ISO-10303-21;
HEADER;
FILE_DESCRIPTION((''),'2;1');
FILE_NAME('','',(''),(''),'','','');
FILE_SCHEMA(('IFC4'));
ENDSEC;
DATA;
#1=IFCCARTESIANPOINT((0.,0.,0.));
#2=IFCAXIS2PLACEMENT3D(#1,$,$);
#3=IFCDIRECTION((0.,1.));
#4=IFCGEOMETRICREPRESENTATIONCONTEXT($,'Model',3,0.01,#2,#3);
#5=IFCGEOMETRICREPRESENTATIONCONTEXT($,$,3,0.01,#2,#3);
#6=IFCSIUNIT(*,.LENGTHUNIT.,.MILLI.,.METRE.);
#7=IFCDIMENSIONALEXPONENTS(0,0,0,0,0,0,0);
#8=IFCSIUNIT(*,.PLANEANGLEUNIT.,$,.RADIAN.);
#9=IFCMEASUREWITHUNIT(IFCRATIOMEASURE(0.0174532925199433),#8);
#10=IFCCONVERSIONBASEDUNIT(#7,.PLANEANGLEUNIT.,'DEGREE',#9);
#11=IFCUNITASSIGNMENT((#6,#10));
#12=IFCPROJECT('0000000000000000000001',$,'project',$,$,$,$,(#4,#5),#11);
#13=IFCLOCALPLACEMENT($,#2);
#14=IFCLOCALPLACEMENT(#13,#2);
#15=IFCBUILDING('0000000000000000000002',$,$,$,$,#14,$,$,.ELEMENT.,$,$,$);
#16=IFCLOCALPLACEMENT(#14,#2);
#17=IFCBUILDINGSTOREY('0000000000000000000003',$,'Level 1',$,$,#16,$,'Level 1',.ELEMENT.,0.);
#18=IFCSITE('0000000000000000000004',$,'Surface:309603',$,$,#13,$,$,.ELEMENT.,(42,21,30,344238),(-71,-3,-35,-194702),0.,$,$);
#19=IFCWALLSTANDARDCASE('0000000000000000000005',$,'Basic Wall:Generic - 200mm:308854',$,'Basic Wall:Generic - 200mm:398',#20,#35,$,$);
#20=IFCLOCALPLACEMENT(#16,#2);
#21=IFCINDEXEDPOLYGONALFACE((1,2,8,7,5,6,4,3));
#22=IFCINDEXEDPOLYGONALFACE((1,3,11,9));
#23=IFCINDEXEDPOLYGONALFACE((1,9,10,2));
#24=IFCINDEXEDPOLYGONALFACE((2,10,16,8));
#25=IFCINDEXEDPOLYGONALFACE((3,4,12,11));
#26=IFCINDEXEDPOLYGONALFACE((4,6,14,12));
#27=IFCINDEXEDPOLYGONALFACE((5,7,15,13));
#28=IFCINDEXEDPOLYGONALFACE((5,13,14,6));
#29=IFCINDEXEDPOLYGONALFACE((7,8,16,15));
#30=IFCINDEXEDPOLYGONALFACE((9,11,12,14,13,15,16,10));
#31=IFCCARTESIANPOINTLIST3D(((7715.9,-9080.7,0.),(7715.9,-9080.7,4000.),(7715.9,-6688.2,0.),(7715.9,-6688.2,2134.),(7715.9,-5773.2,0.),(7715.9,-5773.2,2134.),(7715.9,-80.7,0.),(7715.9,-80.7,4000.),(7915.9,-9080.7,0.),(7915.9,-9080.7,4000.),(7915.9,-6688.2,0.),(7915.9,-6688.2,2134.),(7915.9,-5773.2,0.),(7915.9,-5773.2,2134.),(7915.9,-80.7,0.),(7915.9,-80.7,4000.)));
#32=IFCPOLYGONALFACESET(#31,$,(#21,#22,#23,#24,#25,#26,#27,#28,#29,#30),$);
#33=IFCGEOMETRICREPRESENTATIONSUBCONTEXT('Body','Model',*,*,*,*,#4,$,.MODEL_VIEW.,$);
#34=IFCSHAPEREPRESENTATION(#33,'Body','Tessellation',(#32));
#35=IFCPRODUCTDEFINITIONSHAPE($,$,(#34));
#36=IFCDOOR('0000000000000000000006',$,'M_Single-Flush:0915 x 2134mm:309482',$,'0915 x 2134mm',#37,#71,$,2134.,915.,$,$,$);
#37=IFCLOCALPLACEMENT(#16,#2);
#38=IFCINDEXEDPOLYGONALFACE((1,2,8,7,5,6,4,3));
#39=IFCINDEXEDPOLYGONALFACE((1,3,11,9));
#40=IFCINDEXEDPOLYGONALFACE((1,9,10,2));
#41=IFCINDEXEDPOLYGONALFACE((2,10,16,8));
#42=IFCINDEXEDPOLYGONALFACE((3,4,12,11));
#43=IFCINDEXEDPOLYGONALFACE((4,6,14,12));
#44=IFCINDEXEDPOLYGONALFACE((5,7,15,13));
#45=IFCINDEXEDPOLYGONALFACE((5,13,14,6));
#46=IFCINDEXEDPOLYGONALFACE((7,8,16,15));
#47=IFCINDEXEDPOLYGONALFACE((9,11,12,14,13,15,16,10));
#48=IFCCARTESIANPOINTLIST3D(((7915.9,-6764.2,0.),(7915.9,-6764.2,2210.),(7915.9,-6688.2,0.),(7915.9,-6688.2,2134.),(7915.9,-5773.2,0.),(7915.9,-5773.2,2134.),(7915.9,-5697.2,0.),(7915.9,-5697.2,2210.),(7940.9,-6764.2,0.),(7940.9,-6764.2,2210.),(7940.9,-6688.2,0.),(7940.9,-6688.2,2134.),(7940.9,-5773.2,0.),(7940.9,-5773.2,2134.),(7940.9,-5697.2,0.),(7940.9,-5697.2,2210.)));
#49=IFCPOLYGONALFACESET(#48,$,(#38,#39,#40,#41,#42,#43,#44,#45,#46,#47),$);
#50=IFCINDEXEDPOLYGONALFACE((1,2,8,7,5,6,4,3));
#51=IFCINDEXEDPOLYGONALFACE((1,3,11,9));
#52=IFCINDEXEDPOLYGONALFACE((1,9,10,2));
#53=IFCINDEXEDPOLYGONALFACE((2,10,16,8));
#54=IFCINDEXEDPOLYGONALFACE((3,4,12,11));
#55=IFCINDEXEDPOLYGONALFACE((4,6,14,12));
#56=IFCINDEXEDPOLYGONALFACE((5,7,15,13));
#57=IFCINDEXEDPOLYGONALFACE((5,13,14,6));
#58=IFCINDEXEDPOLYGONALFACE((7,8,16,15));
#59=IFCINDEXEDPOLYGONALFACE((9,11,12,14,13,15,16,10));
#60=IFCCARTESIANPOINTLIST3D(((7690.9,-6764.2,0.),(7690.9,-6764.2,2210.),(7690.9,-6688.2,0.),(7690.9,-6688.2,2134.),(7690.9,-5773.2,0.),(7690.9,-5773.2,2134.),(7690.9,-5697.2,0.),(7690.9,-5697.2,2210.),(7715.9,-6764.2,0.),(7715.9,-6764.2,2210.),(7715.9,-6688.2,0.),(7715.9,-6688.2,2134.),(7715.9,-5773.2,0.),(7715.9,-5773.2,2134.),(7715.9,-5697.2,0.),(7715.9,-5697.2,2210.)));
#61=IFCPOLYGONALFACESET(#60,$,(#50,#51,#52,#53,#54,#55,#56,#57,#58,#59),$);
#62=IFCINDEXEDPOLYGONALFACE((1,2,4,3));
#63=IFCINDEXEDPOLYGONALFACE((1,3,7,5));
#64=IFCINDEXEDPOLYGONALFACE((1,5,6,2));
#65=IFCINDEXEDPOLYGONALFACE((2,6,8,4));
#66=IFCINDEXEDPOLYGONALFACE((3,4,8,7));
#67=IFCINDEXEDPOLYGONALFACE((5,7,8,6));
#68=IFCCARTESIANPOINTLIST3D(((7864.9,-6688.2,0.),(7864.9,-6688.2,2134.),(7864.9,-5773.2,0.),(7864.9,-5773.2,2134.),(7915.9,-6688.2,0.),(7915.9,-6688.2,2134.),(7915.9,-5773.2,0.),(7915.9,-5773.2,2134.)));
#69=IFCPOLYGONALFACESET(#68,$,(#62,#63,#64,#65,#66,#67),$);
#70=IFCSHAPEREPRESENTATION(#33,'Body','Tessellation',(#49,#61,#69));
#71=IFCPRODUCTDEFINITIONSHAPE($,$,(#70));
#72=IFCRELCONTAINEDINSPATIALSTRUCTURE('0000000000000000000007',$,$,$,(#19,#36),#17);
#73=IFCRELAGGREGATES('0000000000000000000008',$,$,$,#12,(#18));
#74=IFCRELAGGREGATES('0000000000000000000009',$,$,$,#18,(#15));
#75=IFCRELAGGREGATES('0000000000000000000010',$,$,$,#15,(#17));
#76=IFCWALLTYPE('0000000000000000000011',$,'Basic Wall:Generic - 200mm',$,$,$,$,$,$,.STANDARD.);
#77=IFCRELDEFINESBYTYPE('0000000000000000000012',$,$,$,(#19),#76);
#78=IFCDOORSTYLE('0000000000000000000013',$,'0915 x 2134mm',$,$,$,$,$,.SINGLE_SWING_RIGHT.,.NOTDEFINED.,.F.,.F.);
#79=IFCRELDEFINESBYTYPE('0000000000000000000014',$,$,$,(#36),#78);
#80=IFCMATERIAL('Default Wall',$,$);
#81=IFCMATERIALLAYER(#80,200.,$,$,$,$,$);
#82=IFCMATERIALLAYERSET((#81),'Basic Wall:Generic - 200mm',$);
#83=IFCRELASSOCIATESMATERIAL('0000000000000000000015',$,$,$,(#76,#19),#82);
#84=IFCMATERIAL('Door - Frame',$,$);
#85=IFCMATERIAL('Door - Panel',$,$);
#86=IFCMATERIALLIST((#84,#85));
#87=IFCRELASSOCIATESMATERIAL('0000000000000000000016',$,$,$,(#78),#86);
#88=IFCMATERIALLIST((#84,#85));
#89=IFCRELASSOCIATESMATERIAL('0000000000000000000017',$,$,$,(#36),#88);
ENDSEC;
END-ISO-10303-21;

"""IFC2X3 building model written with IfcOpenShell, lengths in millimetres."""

from ifc_helpers import new_model, entity, si_unit, converted_unit, direction, frame, frame_2d, origin, place, context, subcontext, project, spatial, polyline, rectangle, outline, extrude, source, transform, mapped, material, material_list, layer, layer_set, layer_usage, type_object, type_shapes, element, fill, save


model = new_model("IFC2X3")

# Units and contexts
model_context = context("Model", 3, precision=0.01, world=origin(), true_north=direction((0.0, 1.0)))
context_of_model = context(None, 3, precision=0.01, world=origin(), true_north=direction((0.0, 1.0)))
body_context = subcontext(model_context, "Body", "Model", "MODEL_VIEW")
ifc_project = project(units=[si_unit("LENGTHUNIT", "METRE", prefix="MILLI"), converted_unit("PLANEANGLEUNIT", "DEGREE", entity("IfcRatioMeasure", 0.0174532925199433), si_unit("PLANEANGLEUNIT", "RADIAN"), dimensions=[0, 0, 0, 0, 0, 0, 0])], contexts=[model_context, context_of_model])

# Site, building, storey
site_placement = place(None, origin())
site = spatial("IfcSite", under=ifc_project, at=site_placement, Name="Surface:309603", CompositionType="ELEMENT", RefLatitude=(42, 21, 30, 344238), RefLongitude=(-71, -3, -35, -194702), RefElevation=0.0)
building_placement = place(site_placement, origin())
building = spatial("IfcBuilding", under=site, at=building_placement, CompositionType="ELEMENT")
storey_placement = place(building_placement, origin())
storey = spatial("IfcBuildingStorey", under=building, at=storey_placement, Name="Level 1", LongName="Level 1", CompositionType="ELEMENT", Elevation=0.0)

# Shared definitions
ifc_material_1 = material(Name="Default Wall")
ifc_layer_1 = layer(ifc_material_1, 200.0)
ifc_layer_set_1 = layer_set([ifc_layer_1], Name="Basic Wall:Generic - 200mm")
wall_type = type_object("IfcWallType", Name="Basic Wall:Generic - 200mm", PredefinedType="STANDARD", material=ifc_layer_set_1)

# Wall, opening, door
ifc_layer_usage_1 = layer_usage(ifc_layer_set_1, "AXIS2", "NEGATIVE", 100.0)
wall_1_placement = place(storey_placement, frame((7815.9, -9080.7, 0.0), z_axis=(0.0, 0.0, 1.0), x_axis=(0.0, 1.0, 0.0)))
wall_1 = element("IfcWallStandardCase", 1, at=wall_1_placement, inside=storey, type_object=wall_type, material=ifc_layer_usage_1, Name="Basic Wall:Generic - 200mm:308854", ObjectType="Basic Wall:Generic - 200mm:398", context=body_context, shape_type="SweptSolid", body=[
    extrude(rectangle(XDim=9000.0, YDim=200.0, at=frame_2d((4500.0, 0.0), x_axis=(-1.0, 0.0))), origin(), (0.0, 0.0, 1.0), 4000.0),
])
opening_1_placement = place(wall_1_placement, frame((3307.5, 100.0, 0.0)))
opening_1 = element("IfcOpeningElement", 2, at=opening_1_placement, cuts=wall_1, ObjectType="Opening", context=body_context, shape_type="SweptSolid", body=[
    extrude(rectangle(XDim=915.0, YDim=2134.0, at=frame_2d((1067.0, 457.5), x_axis=(0.0, 1.0))), frame((0.0, 0.0, 0.0), z_axis=(0.0, -1.0, 0.0), x_axis=(0.0, 0.0, 1.0)), (0.0, 0.0, 1.0), 200.0),
])
ifc_material_2 = material(Name="Door - Frame")
ifc_material_3 = material(Name="Door - Panel")
ifc_material_list_1 = material_list([ifc_material_2, ifc_material_3])
ifc_material_list_2 = material_list([ifc_material_2, ifc_material_3])
door_style = type_object("IfcDoorStyle", Name="0915 x 2134mm", ConstructionType="NOTDEFINED", OperationType="SINGLE_SWING_RIGHT", ParameterTakesPrecedence=False, Sizeable=False, material=ifc_material_list_2)
shared_shape_1 = source(origin(), body_context, "Body", "SweptSolid", [
    extrude(outline(polyline([(-533.5, -1124.0), (533.5, -1124.0), (533.5, 1086.0), (457.5, 1086.0), (457.5, -1048.0), (-457.5, -1048.0), (-457.5, 1086.0), (-533.5, 1086.0), (-533.5, -1124.0)])), frame((457.5, 200.0, 1086.0), z_axis=(0.0, 1.0, 0.0), x_axis=(1.0, 0.0, 0.0)), (0.0, 0.0, 1.0), 25.0),
    extrude(outline(polyline([(-1124.0, -533.5), (1086.0, -533.5), (1086.0, -457.5), (-1048.0, -457.5), (-1048.0, 457.5), (1086.0, 457.5), (1086.0, 533.5), (-1124.0, 533.5), (-1124.0, -533.5)])), frame((457.5, -25.0, 1086.0), z_axis=(0.0, 1.0, 0.0), x_axis=(0.0, 0.0, -1.0)), (0.0, 0.0, 1.0), 25.0),
    extrude(rectangle(XDim=51.0, YDim=915.0, at=frame_2d((0.0, 0.0), x_axis=(1.0, 0.0))), frame((457.5, 174.5, 0.0), z_axis=(0.0, 0.0, 1.0), x_axis=(0.0, 1.0, 0.0)), (0.0, 0.0, 1.0), 2134.0),
])
type_shapes(door_style, [shared_shape_1])
door_1_placement = place(opening_1_placement, frame((0.0, 0.0, 0.0), z_axis=(0.0, 0.0, 1.0), x_axis=(-1.0, 0.0, 0.0)))
door_1 = element("IfcDoor", 3, at=door_1_placement, inside=storey, type_object=door_style, material=ifc_material_list_1, Name="M_Single-Flush:0915 x 2134mm:309482", ObjectType="0915 x 2134mm", OverallHeight=2134.0, OverallWidth=915.0, context=body_context, shape_type="MappedRepresentation", body=[
    mapped(shared_shape_1, transform((0.0, 0.0, 0.0), scale=1.0)),
])
fill(opening_1, door_1)

save(model, "model.ifc")
